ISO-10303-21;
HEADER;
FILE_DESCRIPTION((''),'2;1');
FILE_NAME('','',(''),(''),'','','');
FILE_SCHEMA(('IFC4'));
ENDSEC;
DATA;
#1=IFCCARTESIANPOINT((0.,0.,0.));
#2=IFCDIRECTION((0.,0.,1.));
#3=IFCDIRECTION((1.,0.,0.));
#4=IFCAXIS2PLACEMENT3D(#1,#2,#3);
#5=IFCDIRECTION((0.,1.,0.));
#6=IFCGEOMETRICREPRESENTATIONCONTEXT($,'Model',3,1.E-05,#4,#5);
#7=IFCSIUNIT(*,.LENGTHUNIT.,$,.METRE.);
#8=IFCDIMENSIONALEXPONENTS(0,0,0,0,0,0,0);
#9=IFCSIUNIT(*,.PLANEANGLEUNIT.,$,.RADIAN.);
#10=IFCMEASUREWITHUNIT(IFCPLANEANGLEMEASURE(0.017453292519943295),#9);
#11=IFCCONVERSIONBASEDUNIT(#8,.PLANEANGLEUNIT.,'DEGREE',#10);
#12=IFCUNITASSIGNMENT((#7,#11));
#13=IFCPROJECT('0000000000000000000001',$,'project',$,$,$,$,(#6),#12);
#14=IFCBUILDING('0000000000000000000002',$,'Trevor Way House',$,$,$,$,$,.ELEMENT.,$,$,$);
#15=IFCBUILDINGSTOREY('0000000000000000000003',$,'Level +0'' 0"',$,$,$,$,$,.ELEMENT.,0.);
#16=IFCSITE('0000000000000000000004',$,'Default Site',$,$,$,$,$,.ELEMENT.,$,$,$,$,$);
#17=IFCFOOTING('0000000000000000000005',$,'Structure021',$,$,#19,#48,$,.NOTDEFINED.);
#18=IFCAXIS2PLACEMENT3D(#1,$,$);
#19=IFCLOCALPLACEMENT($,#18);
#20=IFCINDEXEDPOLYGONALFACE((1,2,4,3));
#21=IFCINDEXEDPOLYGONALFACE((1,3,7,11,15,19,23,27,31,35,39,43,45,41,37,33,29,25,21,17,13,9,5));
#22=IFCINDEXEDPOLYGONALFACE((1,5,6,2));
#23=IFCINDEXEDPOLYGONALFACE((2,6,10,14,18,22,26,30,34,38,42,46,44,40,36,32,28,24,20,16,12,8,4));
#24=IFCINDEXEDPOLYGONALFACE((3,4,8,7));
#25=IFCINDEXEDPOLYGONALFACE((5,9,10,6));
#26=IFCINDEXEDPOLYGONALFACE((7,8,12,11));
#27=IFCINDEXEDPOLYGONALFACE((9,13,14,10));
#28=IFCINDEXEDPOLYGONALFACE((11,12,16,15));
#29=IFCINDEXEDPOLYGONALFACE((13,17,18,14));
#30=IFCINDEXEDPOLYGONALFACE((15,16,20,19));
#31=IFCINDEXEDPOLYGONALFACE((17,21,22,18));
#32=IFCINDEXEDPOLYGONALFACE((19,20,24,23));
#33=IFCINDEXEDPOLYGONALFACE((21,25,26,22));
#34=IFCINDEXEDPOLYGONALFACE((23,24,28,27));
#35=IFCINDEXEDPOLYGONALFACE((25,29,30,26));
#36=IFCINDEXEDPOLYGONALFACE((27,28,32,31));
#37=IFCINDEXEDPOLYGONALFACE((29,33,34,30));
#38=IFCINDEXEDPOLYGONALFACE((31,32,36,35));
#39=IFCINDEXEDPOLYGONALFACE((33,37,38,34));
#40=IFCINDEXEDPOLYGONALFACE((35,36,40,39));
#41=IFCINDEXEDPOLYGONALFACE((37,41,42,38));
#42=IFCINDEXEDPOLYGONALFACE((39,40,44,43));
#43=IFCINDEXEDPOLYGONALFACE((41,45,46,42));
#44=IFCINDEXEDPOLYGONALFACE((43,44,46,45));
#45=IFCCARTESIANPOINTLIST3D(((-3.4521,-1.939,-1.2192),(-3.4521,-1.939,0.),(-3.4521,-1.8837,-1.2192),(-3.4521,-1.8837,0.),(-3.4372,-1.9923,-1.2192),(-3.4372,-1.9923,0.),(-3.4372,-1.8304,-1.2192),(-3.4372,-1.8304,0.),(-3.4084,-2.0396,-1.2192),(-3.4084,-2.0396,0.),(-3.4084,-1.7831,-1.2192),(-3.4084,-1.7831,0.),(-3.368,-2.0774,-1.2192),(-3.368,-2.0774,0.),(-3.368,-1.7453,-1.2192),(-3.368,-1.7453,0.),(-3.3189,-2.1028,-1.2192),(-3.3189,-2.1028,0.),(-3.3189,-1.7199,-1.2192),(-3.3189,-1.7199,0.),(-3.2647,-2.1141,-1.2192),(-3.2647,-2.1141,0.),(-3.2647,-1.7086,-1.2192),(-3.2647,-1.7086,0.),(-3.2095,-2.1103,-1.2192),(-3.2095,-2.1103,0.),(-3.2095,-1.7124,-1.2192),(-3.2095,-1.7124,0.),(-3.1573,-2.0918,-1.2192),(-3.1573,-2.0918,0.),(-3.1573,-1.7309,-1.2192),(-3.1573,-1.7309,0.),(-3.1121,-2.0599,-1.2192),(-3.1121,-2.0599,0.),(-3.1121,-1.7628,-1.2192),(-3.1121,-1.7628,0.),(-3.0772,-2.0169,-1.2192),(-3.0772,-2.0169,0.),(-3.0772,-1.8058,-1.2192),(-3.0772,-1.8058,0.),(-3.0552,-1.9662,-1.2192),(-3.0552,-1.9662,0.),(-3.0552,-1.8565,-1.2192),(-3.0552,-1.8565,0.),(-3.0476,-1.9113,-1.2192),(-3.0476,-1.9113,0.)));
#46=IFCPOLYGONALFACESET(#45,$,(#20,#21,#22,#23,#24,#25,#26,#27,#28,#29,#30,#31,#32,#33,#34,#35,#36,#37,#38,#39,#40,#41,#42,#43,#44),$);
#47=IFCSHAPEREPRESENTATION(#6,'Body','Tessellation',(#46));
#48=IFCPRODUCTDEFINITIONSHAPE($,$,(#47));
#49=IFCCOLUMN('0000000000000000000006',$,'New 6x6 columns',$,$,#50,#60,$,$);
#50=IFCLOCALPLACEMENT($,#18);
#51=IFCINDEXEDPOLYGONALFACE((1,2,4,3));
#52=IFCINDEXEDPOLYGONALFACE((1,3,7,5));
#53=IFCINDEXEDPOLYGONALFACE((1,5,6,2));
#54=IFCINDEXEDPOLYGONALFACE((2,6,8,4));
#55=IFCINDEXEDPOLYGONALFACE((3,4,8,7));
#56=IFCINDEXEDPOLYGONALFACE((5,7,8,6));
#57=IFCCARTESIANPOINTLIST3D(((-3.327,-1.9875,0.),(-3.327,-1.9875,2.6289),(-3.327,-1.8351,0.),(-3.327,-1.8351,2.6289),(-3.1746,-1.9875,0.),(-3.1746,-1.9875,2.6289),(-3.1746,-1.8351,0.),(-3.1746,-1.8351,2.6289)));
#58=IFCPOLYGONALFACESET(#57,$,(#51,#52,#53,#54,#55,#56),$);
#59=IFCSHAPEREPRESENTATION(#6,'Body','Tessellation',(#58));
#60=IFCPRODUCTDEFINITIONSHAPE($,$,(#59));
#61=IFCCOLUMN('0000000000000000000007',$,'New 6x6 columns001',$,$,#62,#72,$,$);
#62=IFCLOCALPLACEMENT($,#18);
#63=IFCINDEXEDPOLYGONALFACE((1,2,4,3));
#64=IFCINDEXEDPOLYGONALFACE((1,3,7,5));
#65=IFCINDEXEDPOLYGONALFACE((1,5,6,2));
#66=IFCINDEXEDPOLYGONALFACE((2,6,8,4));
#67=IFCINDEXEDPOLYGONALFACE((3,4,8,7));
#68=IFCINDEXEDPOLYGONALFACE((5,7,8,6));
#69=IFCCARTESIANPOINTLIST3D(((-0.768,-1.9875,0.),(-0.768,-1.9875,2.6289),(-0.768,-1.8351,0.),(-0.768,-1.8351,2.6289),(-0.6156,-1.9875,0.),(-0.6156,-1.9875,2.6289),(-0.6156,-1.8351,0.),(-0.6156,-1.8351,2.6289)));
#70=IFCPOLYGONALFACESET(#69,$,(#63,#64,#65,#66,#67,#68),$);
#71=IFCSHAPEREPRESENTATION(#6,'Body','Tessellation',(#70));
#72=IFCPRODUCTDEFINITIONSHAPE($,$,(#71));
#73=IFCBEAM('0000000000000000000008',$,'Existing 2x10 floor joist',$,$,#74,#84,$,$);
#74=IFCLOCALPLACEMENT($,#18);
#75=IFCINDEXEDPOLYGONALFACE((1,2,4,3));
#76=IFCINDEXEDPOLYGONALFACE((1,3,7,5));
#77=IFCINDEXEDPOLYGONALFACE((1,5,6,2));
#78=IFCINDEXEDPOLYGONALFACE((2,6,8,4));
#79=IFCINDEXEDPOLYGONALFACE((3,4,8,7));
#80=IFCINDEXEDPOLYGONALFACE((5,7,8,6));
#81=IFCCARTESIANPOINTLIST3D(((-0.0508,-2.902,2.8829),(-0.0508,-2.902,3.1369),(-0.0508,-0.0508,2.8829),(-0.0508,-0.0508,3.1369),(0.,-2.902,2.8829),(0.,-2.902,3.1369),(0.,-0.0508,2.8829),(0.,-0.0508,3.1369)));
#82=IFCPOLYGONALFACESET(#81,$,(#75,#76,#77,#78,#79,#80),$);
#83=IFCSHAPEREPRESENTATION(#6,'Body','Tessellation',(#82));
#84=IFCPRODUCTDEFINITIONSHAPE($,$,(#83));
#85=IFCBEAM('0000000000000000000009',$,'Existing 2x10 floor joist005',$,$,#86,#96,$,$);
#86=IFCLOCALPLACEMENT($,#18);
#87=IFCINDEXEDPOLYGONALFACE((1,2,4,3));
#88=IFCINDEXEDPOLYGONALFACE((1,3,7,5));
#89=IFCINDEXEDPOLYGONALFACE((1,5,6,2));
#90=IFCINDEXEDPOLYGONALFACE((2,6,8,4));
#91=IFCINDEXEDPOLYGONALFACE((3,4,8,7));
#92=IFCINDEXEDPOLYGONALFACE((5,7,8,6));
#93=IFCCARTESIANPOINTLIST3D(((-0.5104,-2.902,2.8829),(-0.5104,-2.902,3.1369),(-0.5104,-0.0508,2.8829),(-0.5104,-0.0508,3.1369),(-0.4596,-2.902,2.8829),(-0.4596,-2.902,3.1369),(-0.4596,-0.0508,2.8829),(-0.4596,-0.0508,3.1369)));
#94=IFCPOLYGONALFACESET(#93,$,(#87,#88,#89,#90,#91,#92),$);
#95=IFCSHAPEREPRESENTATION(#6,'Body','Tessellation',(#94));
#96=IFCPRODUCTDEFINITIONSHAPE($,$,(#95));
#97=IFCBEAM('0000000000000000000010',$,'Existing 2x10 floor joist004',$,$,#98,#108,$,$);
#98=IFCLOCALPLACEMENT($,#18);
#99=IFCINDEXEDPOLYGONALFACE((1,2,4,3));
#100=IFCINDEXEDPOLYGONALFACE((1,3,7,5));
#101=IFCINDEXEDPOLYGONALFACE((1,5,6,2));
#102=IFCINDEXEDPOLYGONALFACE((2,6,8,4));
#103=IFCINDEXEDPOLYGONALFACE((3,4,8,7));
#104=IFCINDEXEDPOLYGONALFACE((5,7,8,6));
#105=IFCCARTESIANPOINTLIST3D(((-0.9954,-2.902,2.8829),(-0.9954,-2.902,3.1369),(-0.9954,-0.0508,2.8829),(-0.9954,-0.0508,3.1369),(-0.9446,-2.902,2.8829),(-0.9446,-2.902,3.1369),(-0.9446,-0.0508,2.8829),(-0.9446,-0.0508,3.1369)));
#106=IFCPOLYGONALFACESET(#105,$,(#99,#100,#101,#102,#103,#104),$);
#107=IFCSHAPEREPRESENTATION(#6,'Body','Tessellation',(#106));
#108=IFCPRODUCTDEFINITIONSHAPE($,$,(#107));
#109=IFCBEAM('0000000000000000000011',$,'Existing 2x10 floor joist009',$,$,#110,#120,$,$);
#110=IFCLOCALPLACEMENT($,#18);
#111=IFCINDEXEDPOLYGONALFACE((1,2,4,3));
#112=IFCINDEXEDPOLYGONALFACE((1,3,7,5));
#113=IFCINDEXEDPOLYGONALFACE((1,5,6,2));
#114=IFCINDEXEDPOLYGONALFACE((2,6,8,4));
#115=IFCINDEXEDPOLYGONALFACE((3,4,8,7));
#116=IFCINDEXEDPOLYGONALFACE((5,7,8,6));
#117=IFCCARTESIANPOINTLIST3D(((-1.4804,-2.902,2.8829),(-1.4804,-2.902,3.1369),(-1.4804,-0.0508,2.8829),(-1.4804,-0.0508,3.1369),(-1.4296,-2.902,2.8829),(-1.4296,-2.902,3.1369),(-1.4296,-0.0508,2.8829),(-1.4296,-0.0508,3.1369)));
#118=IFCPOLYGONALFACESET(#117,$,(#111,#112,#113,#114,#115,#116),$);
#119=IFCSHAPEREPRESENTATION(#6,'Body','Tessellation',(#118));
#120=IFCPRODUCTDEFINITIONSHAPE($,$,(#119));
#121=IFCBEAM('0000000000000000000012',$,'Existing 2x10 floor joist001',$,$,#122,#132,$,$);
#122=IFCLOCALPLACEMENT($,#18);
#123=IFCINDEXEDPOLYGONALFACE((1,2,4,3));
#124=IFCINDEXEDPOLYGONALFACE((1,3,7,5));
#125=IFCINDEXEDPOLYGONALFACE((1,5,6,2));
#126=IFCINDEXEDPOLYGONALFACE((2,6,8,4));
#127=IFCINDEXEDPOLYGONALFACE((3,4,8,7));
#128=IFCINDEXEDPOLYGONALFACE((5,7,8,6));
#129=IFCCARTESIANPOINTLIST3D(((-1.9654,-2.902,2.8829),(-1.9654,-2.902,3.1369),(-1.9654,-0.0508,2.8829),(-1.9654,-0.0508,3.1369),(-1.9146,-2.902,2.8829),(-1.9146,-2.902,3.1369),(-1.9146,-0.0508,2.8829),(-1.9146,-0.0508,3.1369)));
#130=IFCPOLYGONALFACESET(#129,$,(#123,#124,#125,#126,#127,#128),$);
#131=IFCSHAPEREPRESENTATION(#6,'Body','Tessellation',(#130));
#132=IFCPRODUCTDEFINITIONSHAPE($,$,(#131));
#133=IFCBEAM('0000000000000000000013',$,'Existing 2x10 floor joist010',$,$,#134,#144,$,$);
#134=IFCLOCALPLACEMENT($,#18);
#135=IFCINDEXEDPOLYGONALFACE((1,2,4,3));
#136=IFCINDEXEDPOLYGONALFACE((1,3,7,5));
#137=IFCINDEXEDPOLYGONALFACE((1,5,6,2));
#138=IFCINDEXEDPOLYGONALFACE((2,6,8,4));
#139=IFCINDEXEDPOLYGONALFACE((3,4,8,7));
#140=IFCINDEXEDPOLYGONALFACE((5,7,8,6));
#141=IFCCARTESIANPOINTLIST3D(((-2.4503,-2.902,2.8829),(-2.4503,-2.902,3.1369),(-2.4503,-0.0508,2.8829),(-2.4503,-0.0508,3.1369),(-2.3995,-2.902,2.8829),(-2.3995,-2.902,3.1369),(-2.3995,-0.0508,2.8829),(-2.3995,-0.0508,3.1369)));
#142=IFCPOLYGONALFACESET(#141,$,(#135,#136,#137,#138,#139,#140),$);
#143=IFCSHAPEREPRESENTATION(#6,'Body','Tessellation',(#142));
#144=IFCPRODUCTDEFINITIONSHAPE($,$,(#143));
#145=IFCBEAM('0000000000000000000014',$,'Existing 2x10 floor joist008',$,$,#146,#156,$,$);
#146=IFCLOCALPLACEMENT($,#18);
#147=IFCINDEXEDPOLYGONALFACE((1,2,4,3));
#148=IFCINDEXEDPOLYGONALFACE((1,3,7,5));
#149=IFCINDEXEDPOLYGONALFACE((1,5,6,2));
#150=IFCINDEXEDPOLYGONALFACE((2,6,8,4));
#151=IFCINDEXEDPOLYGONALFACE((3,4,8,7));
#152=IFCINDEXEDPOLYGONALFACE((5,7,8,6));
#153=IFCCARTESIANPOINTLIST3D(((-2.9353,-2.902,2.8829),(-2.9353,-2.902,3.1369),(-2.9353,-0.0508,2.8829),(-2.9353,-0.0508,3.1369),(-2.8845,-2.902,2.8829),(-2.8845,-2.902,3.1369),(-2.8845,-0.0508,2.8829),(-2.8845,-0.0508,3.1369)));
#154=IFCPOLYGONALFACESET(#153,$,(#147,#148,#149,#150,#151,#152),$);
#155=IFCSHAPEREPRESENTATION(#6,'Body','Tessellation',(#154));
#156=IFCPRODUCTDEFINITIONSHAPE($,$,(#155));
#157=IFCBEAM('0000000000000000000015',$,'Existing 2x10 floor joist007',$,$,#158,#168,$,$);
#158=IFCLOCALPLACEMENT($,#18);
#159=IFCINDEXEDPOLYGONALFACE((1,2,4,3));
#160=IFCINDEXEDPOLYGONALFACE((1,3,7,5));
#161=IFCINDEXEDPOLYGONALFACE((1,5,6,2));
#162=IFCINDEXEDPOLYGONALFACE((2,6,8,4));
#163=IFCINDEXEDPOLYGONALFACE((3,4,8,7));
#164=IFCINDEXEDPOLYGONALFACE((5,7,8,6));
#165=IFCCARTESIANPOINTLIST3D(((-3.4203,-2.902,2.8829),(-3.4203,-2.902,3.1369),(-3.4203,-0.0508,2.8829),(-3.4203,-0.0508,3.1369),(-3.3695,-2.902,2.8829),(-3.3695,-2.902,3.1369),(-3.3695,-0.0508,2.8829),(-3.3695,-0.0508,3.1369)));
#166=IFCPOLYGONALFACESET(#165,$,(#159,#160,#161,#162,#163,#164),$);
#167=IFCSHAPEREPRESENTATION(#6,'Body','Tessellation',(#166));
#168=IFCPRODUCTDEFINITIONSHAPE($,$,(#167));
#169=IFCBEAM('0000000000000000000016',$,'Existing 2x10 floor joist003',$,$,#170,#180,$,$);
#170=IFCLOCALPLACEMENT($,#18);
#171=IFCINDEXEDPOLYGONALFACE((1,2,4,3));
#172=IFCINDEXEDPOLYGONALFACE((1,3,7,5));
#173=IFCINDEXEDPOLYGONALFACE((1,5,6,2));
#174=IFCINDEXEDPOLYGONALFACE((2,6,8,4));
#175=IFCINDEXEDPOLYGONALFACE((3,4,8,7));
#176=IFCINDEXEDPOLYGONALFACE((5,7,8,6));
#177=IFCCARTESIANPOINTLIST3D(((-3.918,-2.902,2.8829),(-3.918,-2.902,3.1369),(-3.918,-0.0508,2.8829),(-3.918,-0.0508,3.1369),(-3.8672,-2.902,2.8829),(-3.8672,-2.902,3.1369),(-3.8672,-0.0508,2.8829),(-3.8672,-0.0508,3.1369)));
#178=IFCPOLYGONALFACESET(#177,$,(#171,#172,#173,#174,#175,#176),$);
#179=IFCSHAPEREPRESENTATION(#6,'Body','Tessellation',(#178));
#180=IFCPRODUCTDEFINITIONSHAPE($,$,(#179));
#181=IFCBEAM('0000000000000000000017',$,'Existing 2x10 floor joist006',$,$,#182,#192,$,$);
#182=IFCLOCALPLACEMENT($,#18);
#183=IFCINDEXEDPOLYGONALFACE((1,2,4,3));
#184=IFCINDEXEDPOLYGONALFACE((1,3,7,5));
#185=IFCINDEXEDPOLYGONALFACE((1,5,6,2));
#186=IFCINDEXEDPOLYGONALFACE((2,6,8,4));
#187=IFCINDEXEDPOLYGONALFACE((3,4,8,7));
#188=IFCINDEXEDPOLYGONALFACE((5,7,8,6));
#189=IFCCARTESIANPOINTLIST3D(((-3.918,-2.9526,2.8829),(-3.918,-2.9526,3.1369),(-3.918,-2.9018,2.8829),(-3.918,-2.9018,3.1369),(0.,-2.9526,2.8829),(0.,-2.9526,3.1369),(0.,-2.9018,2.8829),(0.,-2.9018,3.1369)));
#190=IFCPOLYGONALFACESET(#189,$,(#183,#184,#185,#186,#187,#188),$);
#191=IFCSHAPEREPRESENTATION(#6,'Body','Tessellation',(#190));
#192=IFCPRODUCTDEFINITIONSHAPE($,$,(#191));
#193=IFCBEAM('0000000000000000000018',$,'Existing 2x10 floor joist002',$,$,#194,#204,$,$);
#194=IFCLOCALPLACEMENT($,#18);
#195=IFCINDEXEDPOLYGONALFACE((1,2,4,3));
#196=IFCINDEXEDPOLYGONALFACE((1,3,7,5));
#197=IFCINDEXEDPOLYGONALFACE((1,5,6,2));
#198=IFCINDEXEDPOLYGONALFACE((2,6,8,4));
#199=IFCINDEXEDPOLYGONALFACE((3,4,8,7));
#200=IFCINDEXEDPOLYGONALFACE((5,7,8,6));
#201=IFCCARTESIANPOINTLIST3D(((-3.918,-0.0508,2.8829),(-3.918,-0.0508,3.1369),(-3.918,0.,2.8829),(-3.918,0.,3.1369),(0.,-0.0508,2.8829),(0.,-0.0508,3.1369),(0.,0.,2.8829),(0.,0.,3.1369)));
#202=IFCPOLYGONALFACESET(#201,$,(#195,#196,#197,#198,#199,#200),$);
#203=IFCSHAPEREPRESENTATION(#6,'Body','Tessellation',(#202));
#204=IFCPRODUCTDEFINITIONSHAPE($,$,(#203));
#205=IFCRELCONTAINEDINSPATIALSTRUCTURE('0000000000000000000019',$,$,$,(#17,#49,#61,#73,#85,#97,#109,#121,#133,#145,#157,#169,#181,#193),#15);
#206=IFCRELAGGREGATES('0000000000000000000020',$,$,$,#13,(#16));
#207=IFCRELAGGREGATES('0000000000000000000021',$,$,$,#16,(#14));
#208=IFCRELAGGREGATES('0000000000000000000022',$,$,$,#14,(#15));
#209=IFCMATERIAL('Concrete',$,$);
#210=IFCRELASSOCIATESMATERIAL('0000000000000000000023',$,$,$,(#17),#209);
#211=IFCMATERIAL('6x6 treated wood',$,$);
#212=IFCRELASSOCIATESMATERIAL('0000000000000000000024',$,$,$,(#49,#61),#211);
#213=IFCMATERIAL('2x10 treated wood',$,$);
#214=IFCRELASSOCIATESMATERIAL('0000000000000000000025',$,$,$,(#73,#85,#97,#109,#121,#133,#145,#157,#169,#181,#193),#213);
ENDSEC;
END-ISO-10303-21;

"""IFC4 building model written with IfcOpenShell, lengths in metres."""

from ifc_helpers import new_model, entity, si_unit, converted_unit, direction, frame, origin_with_axes, origin_2d_with_axis, place, context, project, spatial, polyline, circle, outline, extrude, source, transform, mapped, material, element, save


model = new_model("IFC4")

# Units and contexts
model_context = context("Model", 3, precision=1e-05, world=origin_with_axes(), true_north=direction((0.0, 1.0, 0.0)))
ifc_project = project(units=[si_unit("LENGTHUNIT", "METRE"), converted_unit("PLANEANGLEUNIT", "DEGREE", entity("IfcPlaneAngleMeasure", 0.017453292519943295), si_unit("PLANEANGLEUNIT", "RADIAN"), dimensions=[0, 0, 0, 0, 0, 0, 0])], contexts=[model_context])

# Site, building, storey
site = spatial("IfcSite", under=ifc_project, Name="Default Site", CompositionType="ELEMENT")
building = spatial("IfcBuilding", under=site, Name="Trevor Way House", CompositionType="ELEMENT")
storey = spatial("IfcBuildingStorey", under=building, Name="Level +0' 0\"", CompositionType="ELEMENT", Elevation=0.0)

# Footing
ifc_material_1 = material(Name="Concrete")
shared_shape_1 = source(origin_with_axes(), model_context, "Body", "SweptSolid", [
    extrude(circle(Radius=0.2032, at=origin_2d_with_axis()), frame((-3.2508, -1.9113, 0.0), z_axis=(0.0, 0.0, 1.0), x_axis=(1.0, 0.0, 0.0)), (0.0, 0.0, -1.0), 1.2192),
])
placement = place(None, origin_with_axes())
element("IfcFooting", 1, at=placement, inside=storey, material=ifc_material_1, Name="Structure021", PredefinedType="NOTDEFINED", context=model_context, shape_type="MappedRepresentation", body=[
    mapped(shared_shape_1, transform((0.0, 0.0, 0.0), x_axis=(1.0, 0.0, 0.0), y_axis=(0.0, 1.0, 0.0), z_axis=(0.0, 0.0, 1.0), scale=1.0)),
])

# Columns
ifc_material_2 = material(Name="6x6 treated wood")
shared_shape_2 = source(origin_with_axes(), model_context, "Body", "SweptSolid", [
    extrude(outline(polyline([(-0.0762, -0.0762), (0.0762, -0.0762), (0.0762, 0.0762), (-0.0762, 0.0762), (-0.0762, -0.0762)])), frame((0.0, 0.0, 0.0), z_axis=(0.0, 0.0, 1.0), x_axis=(1.0, 0.0, 0.0)), (0.0, 0.0, 1.0), 2.6289),
])
element("IfcColumn", 2, at=placement, inside=storey, material=ifc_material_2, Name="New 6x6 columns", context=model_context, shape_type="MappedRepresentation", body=[
    mapped(shared_shape_2, transform((-3.2508, -1.9113, 0.0), x_axis=(1.0, 0.0, 0.0), y_axis=(0.0, 1.0, 0.0), z_axis=(0.0, 0.0, 1.0), scale=1.0)),
])
element("IfcColumn", 3, at=placement, inside=storey, material=ifc_material_2, Name="New 6x6 columns001", context=model_context, shape_type="MappedRepresentation", body=[
    mapped(shared_shape_2, transform((-0.6918, -1.9113, 0.0), x_axis=(1.0, 0.0, 0.0), y_axis=(0.0, 1.0, 0.0), z_axis=(0.0, 0.0, 1.0), scale=1.0)),
])

# Beams
ifc_material_3 = material(Name="2x10 treated wood")
shared_shape_3 = source(origin_with_axes(), model_context, "Body", "SweptSolid", [
    extrude(outline(polyline([(-0.0254, -0.127), (0.0254, -0.127), (0.0254, 0.127), (-0.0254, 0.127), (-0.0254, -0.127)])), frame((0.0, 0.0, 0.0), z_axis=(0.0, 0.0, 1.0), x_axis=(1.0, 0.0, 0.0)), (0.0, 0.0, 1.0), 2.8512),
])
element("IfcBeam", 4, at=placement, inside=storey, material=ifc_material_3, Name="Existing 2x10 floor joist", context=model_context, shape_type="MappedRepresentation", body=[
    mapped(shared_shape_3, transform((-0.0254, -0.0508, 3.0099), x_axis=(1.0, 0.0, 0.0), y_axis=(0.0, 0.0, 1.0), z_axis=(0.0, -1.0, 0.0), scale=1.0)),
])
element("IfcBeam", 5, at=placement, inside=storey, material=ifc_material_3, Name="Existing 2x10 floor joist005", context=model_context, shape_type="MappedRepresentation", body=[
    mapped(shared_shape_3, transform((-0.485, -0.0508, 3.0099), x_axis=(1.0, 0.0, 0.0), y_axis=(0.0, 0.0, 1.0), z_axis=(0.0, -1.0, 0.0), scale=1.0)),
])
element("IfcBeam", 6, at=placement, inside=storey, material=ifc_material_3, Name="Existing 2x10 floor joist004", context=model_context, shape_type="MappedRepresentation", body=[
    mapped(shared_shape_3, transform((-0.97, -0.0508, 3.0099), x_axis=(1.0, 0.0, 0.0), y_axis=(0.0, 0.0, 1.0), z_axis=(0.0, -1.0, 0.0), scale=1.0)),
])
element("IfcBeam", 7, at=placement, inside=storey, material=ifc_material_3, Name="Existing 2x10 floor joist009", context=model_context, shape_type="MappedRepresentation", body=[
    mapped(shared_shape_3, transform((-1.455, -0.0508, 3.0099), x_axis=(1.0, 0.0, 0.0), y_axis=(0.0, 0.0, 1.0), z_axis=(0.0, -1.0, 0.0), scale=1.0)),
])
element("IfcBeam", 8, at=placement, inside=storey, material=ifc_material_3, Name="Existing 2x10 floor joist001", context=model_context, shape_type="MappedRepresentation", body=[
    mapped(shared_shape_3, transform((-1.94, -0.0508, 3.0099), x_axis=(1.0, 0.0, 0.0), y_axis=(0.0, 0.0, 1.0), z_axis=(0.0, -1.0, 0.0), scale=1.0)),
])
element("IfcBeam", 9, at=placement, inside=storey, material=ifc_material_3, Name="Existing 2x10 floor joist010", context=model_context, shape_type="MappedRepresentation", body=[
    mapped(shared_shape_3, transform((-2.4249, -0.0508, 3.0099), x_axis=(1.0, 0.0, 0.0), y_axis=(0.0, 0.0, 1.0), z_axis=(0.0, -1.0, 0.0), scale=1.0)),
])
element("IfcBeam", 10, at=placement, inside=storey, material=ifc_material_3, Name="Existing 2x10 floor joist008", context=model_context, shape_type="MappedRepresentation", body=[
    mapped(shared_shape_3, transform((-2.9099, -0.0508, 3.0099), x_axis=(1.0, 0.0, 0.0), y_axis=(0.0, 0.0, 1.0), z_axis=(0.0, -1.0, 0.0), scale=1.0)),
])
element("IfcBeam", 11, at=placement, inside=storey, material=ifc_material_3, Name="Existing 2x10 floor joist007", context=model_context, shape_type="MappedRepresentation", body=[
    mapped(shared_shape_3, transform((-3.3949, -0.0508, 3.0099), x_axis=(1.0, 0.0, 0.0), y_axis=(0.0, 0.0, 1.0), z_axis=(0.0, -1.0, 0.0), scale=1.0)),
])
element("IfcBeam", 12, at=placement, inside=storey, material=ifc_material_3, Name="Existing 2x10 floor joist003", context=model_context, shape_type="MappedRepresentation", body=[
    mapped(shared_shape_3, transform((-3.8925, -0.0508, 3.0099), x_axis=(1.0, 0.0, 0.0), y_axis=(0.0, 0.0, 1.0), z_axis=(0.0, -1.0, 0.0), scale=1.0)),
])
shared_shape_4 = source(origin_with_axes(), model_context, "Body", "SweptSolid", [
    extrude(outline(polyline([(-0.0254, -0.127), (0.0254, -0.127), (0.0254, 0.127), (-0.0254, 0.127), (-0.0254, -0.127)])), frame((0.0, 0.0, 0.0), z_axis=(0.0, 0.0, 1.0), x_axis=(1.0, 0.0, 0.0)), (0.0, 0.0, 1.0), 3.9179),
])
element("IfcBeam", 13, at=placement, inside=storey, material=ifc_material_3, Name="Existing 2x10 floor joist006", context=model_context, shape_type="MappedRepresentation", body=[
    mapped(shared_shape_4, transform((0.0, -2.9272, 3.0099), x_axis=(0.0, -1.0, 0.0), y_axis=(0.0, 0.0, 1.0), z_axis=(-1.0, 0.0, 0.0), scale=1.0)),
])
element("IfcBeam", 14, at=placement, inside=storey, material=ifc_material_3, Name="Existing 2x10 floor joist002", context=model_context, shape_type="MappedRepresentation", body=[
    mapped(shared_shape_4, transform((0.0, -0.0254, 3.0099), x_axis=(0.0, -1.0, 0.0), y_axis=(0.0, 0.0, 1.0), z_axis=(-1.0, 0.0, 0.0), scale=1.0)),
])

save(model, "model.ifc")
